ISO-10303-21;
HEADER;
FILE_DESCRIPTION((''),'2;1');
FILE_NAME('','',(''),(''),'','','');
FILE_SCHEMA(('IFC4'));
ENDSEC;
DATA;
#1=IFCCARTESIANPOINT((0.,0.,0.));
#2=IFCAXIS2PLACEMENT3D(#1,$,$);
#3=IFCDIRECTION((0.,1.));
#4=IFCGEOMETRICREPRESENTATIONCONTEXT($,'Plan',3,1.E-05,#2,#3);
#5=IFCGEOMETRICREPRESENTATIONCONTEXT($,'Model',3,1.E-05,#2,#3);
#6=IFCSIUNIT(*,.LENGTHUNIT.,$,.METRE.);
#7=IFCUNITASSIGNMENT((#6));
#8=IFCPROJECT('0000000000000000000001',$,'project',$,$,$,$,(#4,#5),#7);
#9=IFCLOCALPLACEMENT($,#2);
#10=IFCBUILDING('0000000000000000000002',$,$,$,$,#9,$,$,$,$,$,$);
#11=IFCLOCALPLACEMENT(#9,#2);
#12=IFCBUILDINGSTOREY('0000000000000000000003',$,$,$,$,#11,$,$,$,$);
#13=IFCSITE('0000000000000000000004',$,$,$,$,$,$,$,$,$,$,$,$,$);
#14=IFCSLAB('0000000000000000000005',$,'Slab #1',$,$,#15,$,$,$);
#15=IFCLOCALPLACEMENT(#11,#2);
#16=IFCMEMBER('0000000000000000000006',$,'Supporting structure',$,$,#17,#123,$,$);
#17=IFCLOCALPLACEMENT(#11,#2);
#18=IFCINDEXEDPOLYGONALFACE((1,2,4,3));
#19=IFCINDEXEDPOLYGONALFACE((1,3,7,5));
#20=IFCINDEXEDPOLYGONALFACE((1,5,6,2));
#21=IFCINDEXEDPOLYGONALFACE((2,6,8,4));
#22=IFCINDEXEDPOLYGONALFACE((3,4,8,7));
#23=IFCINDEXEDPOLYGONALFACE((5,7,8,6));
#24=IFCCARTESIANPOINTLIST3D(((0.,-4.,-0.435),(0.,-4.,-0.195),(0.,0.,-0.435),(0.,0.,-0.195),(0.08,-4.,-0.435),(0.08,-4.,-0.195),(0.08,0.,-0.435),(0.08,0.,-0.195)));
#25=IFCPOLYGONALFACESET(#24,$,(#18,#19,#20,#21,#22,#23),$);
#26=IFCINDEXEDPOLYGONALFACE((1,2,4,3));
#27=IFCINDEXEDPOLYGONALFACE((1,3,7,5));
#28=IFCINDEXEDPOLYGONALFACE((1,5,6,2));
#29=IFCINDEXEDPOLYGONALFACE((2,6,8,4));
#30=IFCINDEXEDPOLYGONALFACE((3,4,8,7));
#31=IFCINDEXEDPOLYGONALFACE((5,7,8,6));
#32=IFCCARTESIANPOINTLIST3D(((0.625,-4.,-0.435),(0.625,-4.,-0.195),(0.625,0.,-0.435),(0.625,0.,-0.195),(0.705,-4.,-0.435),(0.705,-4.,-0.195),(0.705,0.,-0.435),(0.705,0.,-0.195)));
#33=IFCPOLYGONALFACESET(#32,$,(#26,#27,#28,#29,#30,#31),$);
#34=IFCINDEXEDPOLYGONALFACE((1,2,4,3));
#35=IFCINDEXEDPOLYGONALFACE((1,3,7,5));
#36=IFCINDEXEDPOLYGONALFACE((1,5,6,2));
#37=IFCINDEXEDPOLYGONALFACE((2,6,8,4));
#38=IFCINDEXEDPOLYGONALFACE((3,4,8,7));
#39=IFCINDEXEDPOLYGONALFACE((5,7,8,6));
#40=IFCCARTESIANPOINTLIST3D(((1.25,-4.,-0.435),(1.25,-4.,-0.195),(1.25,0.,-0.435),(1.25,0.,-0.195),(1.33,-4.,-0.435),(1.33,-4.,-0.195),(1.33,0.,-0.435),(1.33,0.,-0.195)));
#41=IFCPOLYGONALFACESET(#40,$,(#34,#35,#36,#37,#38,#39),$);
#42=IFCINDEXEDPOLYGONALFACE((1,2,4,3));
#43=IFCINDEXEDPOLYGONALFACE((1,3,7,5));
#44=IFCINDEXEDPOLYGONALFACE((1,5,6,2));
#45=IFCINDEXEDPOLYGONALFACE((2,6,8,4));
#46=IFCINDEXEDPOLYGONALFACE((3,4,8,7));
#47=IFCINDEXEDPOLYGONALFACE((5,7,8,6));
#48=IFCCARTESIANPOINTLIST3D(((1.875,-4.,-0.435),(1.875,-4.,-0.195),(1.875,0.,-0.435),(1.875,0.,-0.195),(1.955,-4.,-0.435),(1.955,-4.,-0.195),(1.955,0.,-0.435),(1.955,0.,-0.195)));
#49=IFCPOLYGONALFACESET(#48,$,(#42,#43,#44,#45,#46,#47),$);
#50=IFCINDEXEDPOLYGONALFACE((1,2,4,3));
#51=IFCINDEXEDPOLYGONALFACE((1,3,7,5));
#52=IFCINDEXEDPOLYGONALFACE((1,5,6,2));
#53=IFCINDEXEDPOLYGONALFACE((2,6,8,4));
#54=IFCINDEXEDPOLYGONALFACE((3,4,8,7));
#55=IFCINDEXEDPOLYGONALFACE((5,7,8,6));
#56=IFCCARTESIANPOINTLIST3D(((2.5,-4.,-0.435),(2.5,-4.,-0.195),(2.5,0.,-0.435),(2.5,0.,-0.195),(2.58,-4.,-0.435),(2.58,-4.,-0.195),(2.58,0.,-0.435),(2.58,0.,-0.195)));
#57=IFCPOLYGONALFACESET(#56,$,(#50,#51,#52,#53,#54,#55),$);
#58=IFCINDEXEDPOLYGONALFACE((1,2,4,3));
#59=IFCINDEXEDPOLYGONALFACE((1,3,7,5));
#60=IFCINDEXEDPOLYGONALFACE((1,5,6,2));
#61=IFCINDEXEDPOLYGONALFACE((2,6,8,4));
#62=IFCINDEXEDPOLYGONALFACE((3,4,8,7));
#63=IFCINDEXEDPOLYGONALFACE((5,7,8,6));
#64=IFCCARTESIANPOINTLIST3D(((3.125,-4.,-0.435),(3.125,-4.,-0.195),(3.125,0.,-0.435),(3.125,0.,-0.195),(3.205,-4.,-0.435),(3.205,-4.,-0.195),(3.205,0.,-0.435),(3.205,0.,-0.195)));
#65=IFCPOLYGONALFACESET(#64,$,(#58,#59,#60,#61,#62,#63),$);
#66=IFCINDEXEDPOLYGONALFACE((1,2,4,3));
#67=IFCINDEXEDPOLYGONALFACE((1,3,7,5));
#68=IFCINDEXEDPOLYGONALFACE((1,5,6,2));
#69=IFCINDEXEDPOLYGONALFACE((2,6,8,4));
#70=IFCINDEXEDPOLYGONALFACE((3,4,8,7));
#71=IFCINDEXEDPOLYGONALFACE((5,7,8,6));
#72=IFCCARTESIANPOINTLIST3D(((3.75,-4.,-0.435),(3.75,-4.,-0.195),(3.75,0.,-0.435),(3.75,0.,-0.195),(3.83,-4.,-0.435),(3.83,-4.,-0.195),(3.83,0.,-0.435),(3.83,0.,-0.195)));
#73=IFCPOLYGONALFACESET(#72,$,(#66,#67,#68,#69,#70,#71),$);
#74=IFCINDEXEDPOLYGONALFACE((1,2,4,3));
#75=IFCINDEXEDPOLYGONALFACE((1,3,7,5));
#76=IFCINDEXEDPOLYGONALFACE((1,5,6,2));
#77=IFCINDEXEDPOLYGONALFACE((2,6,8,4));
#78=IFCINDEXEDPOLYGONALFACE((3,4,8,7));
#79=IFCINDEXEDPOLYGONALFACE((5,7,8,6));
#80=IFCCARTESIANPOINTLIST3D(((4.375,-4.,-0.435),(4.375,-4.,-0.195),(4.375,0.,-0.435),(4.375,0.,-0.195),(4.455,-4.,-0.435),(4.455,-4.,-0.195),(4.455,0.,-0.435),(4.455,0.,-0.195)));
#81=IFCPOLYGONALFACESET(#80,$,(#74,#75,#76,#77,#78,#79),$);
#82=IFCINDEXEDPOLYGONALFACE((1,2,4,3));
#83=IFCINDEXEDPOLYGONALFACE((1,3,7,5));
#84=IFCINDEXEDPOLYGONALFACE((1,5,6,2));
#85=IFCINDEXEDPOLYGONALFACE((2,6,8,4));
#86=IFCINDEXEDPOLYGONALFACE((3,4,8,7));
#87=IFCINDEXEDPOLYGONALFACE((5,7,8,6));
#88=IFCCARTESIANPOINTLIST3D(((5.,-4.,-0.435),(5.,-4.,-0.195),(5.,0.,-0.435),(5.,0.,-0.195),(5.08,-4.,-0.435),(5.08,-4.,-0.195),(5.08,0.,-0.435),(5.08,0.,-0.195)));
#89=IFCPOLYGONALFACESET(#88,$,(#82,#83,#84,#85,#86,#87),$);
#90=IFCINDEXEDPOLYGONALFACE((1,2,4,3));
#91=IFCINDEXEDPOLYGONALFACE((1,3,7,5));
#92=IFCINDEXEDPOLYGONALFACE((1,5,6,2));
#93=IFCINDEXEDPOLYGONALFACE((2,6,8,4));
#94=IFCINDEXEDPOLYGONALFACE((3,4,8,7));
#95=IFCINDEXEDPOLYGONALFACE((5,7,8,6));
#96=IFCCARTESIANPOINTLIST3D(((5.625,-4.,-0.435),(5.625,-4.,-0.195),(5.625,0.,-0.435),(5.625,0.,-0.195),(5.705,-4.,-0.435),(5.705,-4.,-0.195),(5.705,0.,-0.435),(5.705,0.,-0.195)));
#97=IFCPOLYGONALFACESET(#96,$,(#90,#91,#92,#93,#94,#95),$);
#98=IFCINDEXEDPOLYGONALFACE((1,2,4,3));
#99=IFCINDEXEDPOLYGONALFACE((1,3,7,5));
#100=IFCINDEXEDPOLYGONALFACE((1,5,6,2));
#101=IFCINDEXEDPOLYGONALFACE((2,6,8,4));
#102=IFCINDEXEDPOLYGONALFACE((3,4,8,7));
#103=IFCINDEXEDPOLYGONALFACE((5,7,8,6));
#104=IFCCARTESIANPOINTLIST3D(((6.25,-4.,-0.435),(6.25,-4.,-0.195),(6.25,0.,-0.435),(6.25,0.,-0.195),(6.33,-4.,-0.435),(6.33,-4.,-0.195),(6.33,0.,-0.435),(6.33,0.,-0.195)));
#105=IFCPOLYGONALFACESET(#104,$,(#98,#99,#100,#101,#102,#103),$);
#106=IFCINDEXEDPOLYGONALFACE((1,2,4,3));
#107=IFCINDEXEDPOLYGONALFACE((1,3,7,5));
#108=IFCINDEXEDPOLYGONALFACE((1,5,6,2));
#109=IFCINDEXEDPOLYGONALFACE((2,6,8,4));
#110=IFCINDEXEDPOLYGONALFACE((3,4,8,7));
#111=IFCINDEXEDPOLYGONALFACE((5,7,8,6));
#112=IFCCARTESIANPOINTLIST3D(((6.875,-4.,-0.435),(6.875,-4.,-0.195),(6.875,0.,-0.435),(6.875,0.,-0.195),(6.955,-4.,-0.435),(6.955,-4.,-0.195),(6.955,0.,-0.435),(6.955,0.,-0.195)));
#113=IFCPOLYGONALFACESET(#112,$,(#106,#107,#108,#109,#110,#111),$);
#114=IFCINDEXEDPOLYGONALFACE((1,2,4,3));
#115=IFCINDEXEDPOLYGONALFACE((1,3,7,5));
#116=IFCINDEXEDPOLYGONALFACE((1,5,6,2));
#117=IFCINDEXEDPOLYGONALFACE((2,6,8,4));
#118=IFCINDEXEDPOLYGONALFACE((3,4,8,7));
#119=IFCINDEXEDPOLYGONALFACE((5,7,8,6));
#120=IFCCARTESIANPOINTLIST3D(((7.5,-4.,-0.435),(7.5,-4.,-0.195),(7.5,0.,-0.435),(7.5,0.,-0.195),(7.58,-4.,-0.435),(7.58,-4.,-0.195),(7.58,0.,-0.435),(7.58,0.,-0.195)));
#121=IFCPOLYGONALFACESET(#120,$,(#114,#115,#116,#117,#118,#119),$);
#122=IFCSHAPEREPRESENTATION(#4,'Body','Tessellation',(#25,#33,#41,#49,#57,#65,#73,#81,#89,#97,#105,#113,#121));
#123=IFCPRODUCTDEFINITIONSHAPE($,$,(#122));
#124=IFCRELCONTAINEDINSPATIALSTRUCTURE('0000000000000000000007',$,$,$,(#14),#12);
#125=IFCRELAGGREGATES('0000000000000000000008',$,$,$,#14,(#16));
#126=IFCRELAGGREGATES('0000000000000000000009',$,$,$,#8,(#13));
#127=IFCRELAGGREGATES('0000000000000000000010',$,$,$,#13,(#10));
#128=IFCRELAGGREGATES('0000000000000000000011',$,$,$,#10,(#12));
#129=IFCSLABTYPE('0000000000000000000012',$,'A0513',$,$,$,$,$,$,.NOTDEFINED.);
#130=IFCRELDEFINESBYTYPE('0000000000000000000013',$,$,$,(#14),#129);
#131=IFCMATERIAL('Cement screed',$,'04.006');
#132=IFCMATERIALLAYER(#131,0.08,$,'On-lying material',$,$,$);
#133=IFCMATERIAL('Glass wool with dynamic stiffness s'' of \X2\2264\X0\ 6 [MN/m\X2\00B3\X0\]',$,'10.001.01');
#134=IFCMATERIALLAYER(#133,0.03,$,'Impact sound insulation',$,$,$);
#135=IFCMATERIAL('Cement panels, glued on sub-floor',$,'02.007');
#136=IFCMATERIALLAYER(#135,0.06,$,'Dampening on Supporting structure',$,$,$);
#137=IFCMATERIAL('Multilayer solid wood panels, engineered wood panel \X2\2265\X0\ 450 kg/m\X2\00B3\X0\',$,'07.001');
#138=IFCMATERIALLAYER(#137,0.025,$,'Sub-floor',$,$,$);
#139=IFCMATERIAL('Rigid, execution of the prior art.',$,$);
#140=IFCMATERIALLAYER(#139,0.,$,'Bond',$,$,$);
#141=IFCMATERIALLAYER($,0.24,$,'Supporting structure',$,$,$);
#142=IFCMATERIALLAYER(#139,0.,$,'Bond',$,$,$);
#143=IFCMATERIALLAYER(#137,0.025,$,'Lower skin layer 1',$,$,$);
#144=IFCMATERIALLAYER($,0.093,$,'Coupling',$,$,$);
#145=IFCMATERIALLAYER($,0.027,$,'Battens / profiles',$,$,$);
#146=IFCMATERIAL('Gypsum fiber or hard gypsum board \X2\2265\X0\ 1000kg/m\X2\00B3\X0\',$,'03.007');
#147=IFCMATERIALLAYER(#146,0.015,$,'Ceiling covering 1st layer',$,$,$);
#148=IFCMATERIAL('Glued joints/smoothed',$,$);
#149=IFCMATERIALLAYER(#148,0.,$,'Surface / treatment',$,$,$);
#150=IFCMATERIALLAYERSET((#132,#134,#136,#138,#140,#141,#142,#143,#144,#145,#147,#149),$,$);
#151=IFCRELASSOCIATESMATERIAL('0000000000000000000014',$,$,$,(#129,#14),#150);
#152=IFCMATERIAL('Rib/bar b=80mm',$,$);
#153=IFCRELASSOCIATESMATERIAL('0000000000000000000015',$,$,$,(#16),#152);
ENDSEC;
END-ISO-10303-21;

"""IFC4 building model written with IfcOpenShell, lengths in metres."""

from ifc_helpers import new_model, si_unit, direction, frame, frame_2d, origin, place, context, project, spatial, rectangle, extrude, material, layer, layer_set, type_object, element, aggregate, save


model = new_model("IFC4")

# Units and contexts
plan_context = context("Plan", 3, precision=1e-05, world=origin(), true_north=direction((0.0, 1.0)))
model_context = context("Model", 3, precision=1e-05, world=origin(), true_north=direction((0.0, 1.0)))
ifc_project = project(units=[si_unit("LENGTHUNIT", "METRE")], contexts=[plan_context, model_context])

# Site, building, storey
site = spatial("IfcSite", under=ifc_project)
building_placement = place(None, origin())
building = spatial("IfcBuilding", under=site, at=building_placement)
storey_placement = place(building_placement, origin())
storey = spatial("IfcBuildingStorey", under=building, at=storey_placement)

# Slab, member
ifc_material_1 = material(Name="Cement screed", Category="04.006")
ifc_layer_1 = layer(ifc_material_1, 0.08, Name="On-lying material")
ifc_material_2 = material(Name="Glass wool with dynamic stiffness s' of ≤ 6 [MN/m³]", Category="10.001.01")
ifc_layer_2 = layer(ifc_material_2, 0.03, Name="Impact sound insulation")
ifc_material_3 = material(Name="Cement panels, glued on sub-floor", Category="02.007")
ifc_layer_3 = layer(ifc_material_3, 0.06, Name="Dampening on Supporting structure")
ifc_material_4 = material(Name="Multilayer solid wood panels, engineered wood panel ≥ 450 kg/m³", Category="07.001")
ifc_layer_4 = layer(ifc_material_4, 0.025, Name="Sub-floor")
ifc_material_5 = material(Name="Rigid, execution of the prior art.")
ifc_layer_5 = layer(ifc_material_5, 0.0, Name="Bond")
ifc_layer_6 = layer(None, 0.24, Name="Supporting structure")
ifc_layer_7 = layer(ifc_material_5, 0.0, Name="Bond")
ifc_layer_8 = layer(ifc_material_4, 0.025, Name="Lower skin layer 1")
ifc_layer_9 = layer(None, 0.093, Name="Coupling")
ifc_layer_10 = layer(None, 0.027, Name="Battens / profiles")
ifc_material_6 = material(Name="Gypsum fiber or hard gypsum board ≥ 1000kg/m³", Category="03.007")
ifc_layer_11 = layer(ifc_material_6, 0.015, Name="Ceiling covering 1st layer")
ifc_material_7 = material(Name="Glued joints/smoothed")
ifc_layer_12 = layer(ifc_material_7, 0.0, Name="Surface / treatment")
ifc_layer_set = layer_set([ifc_layer_1, ifc_layer_2, ifc_layer_3, ifc_layer_4, ifc_layer_5, ifc_layer_6, ifc_layer_7, ifc_layer_8, ifc_layer_9, ifc_layer_10, ifc_layer_11, ifc_layer_12])
slab_type = type_object("IfcSlabType", Name="A0513", PredefinedType="NOTDEFINED", material=ifc_layer_set)
slab_placement = place(None, frame((0.0, 0.0, 0.0), z_axis=(0.0, 0.0, -1.0), x_axis=(1.0, 0.0, 0.0)))
slab = element("IfcSlab", 1, at=slab_placement, inside=storey, type_object=slab_type, material=ifc_layer_set, Name="Slab #1")
ifc_material_8 = material(Name="Rib/bar b=80mm")
member_1_placement = place(slab_placement, origin())
member_1 = element("IfcMember", 2, at=member_1_placement, material=ifc_material_8, Name="Supporting structure", context=plan_context, shape_type="SweptSolid", body=[
    extrude(rectangle(XDim=0.08, YDim=0.24, at=frame_2d((0.04, 0.12), x_axis=(1.0, 0.0))), frame((0.0, 4.0, 0.195), z_axis=(0.0, -1.0, 0.0), x_axis=(1.0, 0.0, 0.0)), (0.0, 0.0, 1.0), 4.0),
    extrude(rectangle(XDim=0.08, YDim=0.24, at=frame_2d((0.04, 0.12), x_axis=(1.0, 0.0))), frame((0.625, 4.0, 0.195), z_axis=(0.0, -1.0, 0.0), x_axis=(1.0, 0.0, 0.0)), (0.0, 0.0, 1.0), 4.0),
    extrude(rectangle(XDim=0.08, YDim=0.24, at=frame_2d((0.04, 0.12), x_axis=(1.0, 0.0))), frame((1.25, 4.0, 0.195), z_axis=(0.0, -1.0, 0.0), x_axis=(1.0, 0.0, 0.0)), (0.0, 0.0, 1.0), 4.0),
    extrude(rectangle(XDim=0.08, YDim=0.24, at=frame_2d((0.04, 0.12), x_axis=(1.0, 0.0))), frame((1.875, 4.0, 0.195), z_axis=(0.0, -1.0, 0.0), x_axis=(1.0, 0.0, 0.0)), (0.0, 0.0, 1.0), 4.0),
    extrude(rectangle(XDim=0.08, YDim=0.24, at=frame_2d((0.04, 0.12), x_axis=(1.0, 0.0))), frame((2.5, 4.0, 0.195), z_axis=(0.0, -1.0, 0.0), x_axis=(1.0, 0.0, 0.0)), (0.0, 0.0, 1.0), 4.0),
    extrude(rectangle(XDim=0.08, YDim=0.24, at=frame_2d((0.04, 0.12), x_axis=(1.0, 0.0))), frame((3.125, 4.0, 0.195), z_axis=(0.0, -1.0, 0.0), x_axis=(1.0, 0.0, 0.0)), (0.0, 0.0, 1.0), 4.0),
    extrude(rectangle(XDim=0.08, YDim=0.24, at=frame_2d((0.04, 0.12), x_axis=(1.0, 0.0))), frame((3.75, 4.0, 0.195), z_axis=(0.0, -1.0, 0.0), x_axis=(1.0, 0.0, 0.0)), (0.0, 0.0, 1.0), 4.0),
    extrude(rectangle(XDim=0.08, YDim=0.24, at=frame_2d((0.04, 0.12), x_axis=(1.0, 0.0))), frame((4.375, 4.0, 0.195), z_axis=(0.0, -1.0, 0.0), x_axis=(1.0, 0.0, 0.0)), (0.0, 0.0, 1.0), 4.0),
    extrude(rectangle(XDim=0.08, YDim=0.24, at=frame_2d((0.04, 0.12), x_axis=(1.0, 0.0))), frame((5.0, 4.0, 0.195), z_axis=(0.0, -1.0, 0.0), x_axis=(1.0, 0.0, 0.0)), (0.0, 0.0, 1.0), 4.0),
    extrude(rectangle(XDim=0.08, YDim=0.24, at=frame_2d((0.04, 0.12), x_axis=(1.0, 0.0))), frame((5.625, 4.0, 0.195), z_axis=(0.0, -1.0, 0.0), x_axis=(1.0, 0.0, 0.0)), (0.0, 0.0, 1.0), 4.0),
    extrude(rectangle(XDim=0.08, YDim=0.24, at=frame_2d((0.04, 0.12), x_axis=(1.0, 0.0))), frame((6.25, 4.0, 0.195), z_axis=(0.0, -1.0, 0.0), x_axis=(1.0, 0.0, 0.0)), (0.0, 0.0, 1.0), 4.0),
    extrude(rectangle(XDim=0.08, YDim=0.24, at=frame_2d((0.04, 0.12), x_axis=(1.0, 0.0))), frame((6.875, 4.0, 0.195), z_axis=(0.0, -1.0, 0.0), x_axis=(1.0, 0.0, 0.0)), (0.0, 0.0, 1.0), 4.0),
    extrude(rectangle(XDim=0.08, YDim=0.24, at=frame_2d((0.04, 0.12), x_axis=(1.0, 0.0))), frame((7.5, 4.0, 0.195), z_axis=(0.0, -1.0, 0.0), x_axis=(1.0, 0.0, 0.0)), (0.0, 0.0, 1.0), 4.0),
])
aggregate(slab, [member_1])

save(model, "model.ifc")
